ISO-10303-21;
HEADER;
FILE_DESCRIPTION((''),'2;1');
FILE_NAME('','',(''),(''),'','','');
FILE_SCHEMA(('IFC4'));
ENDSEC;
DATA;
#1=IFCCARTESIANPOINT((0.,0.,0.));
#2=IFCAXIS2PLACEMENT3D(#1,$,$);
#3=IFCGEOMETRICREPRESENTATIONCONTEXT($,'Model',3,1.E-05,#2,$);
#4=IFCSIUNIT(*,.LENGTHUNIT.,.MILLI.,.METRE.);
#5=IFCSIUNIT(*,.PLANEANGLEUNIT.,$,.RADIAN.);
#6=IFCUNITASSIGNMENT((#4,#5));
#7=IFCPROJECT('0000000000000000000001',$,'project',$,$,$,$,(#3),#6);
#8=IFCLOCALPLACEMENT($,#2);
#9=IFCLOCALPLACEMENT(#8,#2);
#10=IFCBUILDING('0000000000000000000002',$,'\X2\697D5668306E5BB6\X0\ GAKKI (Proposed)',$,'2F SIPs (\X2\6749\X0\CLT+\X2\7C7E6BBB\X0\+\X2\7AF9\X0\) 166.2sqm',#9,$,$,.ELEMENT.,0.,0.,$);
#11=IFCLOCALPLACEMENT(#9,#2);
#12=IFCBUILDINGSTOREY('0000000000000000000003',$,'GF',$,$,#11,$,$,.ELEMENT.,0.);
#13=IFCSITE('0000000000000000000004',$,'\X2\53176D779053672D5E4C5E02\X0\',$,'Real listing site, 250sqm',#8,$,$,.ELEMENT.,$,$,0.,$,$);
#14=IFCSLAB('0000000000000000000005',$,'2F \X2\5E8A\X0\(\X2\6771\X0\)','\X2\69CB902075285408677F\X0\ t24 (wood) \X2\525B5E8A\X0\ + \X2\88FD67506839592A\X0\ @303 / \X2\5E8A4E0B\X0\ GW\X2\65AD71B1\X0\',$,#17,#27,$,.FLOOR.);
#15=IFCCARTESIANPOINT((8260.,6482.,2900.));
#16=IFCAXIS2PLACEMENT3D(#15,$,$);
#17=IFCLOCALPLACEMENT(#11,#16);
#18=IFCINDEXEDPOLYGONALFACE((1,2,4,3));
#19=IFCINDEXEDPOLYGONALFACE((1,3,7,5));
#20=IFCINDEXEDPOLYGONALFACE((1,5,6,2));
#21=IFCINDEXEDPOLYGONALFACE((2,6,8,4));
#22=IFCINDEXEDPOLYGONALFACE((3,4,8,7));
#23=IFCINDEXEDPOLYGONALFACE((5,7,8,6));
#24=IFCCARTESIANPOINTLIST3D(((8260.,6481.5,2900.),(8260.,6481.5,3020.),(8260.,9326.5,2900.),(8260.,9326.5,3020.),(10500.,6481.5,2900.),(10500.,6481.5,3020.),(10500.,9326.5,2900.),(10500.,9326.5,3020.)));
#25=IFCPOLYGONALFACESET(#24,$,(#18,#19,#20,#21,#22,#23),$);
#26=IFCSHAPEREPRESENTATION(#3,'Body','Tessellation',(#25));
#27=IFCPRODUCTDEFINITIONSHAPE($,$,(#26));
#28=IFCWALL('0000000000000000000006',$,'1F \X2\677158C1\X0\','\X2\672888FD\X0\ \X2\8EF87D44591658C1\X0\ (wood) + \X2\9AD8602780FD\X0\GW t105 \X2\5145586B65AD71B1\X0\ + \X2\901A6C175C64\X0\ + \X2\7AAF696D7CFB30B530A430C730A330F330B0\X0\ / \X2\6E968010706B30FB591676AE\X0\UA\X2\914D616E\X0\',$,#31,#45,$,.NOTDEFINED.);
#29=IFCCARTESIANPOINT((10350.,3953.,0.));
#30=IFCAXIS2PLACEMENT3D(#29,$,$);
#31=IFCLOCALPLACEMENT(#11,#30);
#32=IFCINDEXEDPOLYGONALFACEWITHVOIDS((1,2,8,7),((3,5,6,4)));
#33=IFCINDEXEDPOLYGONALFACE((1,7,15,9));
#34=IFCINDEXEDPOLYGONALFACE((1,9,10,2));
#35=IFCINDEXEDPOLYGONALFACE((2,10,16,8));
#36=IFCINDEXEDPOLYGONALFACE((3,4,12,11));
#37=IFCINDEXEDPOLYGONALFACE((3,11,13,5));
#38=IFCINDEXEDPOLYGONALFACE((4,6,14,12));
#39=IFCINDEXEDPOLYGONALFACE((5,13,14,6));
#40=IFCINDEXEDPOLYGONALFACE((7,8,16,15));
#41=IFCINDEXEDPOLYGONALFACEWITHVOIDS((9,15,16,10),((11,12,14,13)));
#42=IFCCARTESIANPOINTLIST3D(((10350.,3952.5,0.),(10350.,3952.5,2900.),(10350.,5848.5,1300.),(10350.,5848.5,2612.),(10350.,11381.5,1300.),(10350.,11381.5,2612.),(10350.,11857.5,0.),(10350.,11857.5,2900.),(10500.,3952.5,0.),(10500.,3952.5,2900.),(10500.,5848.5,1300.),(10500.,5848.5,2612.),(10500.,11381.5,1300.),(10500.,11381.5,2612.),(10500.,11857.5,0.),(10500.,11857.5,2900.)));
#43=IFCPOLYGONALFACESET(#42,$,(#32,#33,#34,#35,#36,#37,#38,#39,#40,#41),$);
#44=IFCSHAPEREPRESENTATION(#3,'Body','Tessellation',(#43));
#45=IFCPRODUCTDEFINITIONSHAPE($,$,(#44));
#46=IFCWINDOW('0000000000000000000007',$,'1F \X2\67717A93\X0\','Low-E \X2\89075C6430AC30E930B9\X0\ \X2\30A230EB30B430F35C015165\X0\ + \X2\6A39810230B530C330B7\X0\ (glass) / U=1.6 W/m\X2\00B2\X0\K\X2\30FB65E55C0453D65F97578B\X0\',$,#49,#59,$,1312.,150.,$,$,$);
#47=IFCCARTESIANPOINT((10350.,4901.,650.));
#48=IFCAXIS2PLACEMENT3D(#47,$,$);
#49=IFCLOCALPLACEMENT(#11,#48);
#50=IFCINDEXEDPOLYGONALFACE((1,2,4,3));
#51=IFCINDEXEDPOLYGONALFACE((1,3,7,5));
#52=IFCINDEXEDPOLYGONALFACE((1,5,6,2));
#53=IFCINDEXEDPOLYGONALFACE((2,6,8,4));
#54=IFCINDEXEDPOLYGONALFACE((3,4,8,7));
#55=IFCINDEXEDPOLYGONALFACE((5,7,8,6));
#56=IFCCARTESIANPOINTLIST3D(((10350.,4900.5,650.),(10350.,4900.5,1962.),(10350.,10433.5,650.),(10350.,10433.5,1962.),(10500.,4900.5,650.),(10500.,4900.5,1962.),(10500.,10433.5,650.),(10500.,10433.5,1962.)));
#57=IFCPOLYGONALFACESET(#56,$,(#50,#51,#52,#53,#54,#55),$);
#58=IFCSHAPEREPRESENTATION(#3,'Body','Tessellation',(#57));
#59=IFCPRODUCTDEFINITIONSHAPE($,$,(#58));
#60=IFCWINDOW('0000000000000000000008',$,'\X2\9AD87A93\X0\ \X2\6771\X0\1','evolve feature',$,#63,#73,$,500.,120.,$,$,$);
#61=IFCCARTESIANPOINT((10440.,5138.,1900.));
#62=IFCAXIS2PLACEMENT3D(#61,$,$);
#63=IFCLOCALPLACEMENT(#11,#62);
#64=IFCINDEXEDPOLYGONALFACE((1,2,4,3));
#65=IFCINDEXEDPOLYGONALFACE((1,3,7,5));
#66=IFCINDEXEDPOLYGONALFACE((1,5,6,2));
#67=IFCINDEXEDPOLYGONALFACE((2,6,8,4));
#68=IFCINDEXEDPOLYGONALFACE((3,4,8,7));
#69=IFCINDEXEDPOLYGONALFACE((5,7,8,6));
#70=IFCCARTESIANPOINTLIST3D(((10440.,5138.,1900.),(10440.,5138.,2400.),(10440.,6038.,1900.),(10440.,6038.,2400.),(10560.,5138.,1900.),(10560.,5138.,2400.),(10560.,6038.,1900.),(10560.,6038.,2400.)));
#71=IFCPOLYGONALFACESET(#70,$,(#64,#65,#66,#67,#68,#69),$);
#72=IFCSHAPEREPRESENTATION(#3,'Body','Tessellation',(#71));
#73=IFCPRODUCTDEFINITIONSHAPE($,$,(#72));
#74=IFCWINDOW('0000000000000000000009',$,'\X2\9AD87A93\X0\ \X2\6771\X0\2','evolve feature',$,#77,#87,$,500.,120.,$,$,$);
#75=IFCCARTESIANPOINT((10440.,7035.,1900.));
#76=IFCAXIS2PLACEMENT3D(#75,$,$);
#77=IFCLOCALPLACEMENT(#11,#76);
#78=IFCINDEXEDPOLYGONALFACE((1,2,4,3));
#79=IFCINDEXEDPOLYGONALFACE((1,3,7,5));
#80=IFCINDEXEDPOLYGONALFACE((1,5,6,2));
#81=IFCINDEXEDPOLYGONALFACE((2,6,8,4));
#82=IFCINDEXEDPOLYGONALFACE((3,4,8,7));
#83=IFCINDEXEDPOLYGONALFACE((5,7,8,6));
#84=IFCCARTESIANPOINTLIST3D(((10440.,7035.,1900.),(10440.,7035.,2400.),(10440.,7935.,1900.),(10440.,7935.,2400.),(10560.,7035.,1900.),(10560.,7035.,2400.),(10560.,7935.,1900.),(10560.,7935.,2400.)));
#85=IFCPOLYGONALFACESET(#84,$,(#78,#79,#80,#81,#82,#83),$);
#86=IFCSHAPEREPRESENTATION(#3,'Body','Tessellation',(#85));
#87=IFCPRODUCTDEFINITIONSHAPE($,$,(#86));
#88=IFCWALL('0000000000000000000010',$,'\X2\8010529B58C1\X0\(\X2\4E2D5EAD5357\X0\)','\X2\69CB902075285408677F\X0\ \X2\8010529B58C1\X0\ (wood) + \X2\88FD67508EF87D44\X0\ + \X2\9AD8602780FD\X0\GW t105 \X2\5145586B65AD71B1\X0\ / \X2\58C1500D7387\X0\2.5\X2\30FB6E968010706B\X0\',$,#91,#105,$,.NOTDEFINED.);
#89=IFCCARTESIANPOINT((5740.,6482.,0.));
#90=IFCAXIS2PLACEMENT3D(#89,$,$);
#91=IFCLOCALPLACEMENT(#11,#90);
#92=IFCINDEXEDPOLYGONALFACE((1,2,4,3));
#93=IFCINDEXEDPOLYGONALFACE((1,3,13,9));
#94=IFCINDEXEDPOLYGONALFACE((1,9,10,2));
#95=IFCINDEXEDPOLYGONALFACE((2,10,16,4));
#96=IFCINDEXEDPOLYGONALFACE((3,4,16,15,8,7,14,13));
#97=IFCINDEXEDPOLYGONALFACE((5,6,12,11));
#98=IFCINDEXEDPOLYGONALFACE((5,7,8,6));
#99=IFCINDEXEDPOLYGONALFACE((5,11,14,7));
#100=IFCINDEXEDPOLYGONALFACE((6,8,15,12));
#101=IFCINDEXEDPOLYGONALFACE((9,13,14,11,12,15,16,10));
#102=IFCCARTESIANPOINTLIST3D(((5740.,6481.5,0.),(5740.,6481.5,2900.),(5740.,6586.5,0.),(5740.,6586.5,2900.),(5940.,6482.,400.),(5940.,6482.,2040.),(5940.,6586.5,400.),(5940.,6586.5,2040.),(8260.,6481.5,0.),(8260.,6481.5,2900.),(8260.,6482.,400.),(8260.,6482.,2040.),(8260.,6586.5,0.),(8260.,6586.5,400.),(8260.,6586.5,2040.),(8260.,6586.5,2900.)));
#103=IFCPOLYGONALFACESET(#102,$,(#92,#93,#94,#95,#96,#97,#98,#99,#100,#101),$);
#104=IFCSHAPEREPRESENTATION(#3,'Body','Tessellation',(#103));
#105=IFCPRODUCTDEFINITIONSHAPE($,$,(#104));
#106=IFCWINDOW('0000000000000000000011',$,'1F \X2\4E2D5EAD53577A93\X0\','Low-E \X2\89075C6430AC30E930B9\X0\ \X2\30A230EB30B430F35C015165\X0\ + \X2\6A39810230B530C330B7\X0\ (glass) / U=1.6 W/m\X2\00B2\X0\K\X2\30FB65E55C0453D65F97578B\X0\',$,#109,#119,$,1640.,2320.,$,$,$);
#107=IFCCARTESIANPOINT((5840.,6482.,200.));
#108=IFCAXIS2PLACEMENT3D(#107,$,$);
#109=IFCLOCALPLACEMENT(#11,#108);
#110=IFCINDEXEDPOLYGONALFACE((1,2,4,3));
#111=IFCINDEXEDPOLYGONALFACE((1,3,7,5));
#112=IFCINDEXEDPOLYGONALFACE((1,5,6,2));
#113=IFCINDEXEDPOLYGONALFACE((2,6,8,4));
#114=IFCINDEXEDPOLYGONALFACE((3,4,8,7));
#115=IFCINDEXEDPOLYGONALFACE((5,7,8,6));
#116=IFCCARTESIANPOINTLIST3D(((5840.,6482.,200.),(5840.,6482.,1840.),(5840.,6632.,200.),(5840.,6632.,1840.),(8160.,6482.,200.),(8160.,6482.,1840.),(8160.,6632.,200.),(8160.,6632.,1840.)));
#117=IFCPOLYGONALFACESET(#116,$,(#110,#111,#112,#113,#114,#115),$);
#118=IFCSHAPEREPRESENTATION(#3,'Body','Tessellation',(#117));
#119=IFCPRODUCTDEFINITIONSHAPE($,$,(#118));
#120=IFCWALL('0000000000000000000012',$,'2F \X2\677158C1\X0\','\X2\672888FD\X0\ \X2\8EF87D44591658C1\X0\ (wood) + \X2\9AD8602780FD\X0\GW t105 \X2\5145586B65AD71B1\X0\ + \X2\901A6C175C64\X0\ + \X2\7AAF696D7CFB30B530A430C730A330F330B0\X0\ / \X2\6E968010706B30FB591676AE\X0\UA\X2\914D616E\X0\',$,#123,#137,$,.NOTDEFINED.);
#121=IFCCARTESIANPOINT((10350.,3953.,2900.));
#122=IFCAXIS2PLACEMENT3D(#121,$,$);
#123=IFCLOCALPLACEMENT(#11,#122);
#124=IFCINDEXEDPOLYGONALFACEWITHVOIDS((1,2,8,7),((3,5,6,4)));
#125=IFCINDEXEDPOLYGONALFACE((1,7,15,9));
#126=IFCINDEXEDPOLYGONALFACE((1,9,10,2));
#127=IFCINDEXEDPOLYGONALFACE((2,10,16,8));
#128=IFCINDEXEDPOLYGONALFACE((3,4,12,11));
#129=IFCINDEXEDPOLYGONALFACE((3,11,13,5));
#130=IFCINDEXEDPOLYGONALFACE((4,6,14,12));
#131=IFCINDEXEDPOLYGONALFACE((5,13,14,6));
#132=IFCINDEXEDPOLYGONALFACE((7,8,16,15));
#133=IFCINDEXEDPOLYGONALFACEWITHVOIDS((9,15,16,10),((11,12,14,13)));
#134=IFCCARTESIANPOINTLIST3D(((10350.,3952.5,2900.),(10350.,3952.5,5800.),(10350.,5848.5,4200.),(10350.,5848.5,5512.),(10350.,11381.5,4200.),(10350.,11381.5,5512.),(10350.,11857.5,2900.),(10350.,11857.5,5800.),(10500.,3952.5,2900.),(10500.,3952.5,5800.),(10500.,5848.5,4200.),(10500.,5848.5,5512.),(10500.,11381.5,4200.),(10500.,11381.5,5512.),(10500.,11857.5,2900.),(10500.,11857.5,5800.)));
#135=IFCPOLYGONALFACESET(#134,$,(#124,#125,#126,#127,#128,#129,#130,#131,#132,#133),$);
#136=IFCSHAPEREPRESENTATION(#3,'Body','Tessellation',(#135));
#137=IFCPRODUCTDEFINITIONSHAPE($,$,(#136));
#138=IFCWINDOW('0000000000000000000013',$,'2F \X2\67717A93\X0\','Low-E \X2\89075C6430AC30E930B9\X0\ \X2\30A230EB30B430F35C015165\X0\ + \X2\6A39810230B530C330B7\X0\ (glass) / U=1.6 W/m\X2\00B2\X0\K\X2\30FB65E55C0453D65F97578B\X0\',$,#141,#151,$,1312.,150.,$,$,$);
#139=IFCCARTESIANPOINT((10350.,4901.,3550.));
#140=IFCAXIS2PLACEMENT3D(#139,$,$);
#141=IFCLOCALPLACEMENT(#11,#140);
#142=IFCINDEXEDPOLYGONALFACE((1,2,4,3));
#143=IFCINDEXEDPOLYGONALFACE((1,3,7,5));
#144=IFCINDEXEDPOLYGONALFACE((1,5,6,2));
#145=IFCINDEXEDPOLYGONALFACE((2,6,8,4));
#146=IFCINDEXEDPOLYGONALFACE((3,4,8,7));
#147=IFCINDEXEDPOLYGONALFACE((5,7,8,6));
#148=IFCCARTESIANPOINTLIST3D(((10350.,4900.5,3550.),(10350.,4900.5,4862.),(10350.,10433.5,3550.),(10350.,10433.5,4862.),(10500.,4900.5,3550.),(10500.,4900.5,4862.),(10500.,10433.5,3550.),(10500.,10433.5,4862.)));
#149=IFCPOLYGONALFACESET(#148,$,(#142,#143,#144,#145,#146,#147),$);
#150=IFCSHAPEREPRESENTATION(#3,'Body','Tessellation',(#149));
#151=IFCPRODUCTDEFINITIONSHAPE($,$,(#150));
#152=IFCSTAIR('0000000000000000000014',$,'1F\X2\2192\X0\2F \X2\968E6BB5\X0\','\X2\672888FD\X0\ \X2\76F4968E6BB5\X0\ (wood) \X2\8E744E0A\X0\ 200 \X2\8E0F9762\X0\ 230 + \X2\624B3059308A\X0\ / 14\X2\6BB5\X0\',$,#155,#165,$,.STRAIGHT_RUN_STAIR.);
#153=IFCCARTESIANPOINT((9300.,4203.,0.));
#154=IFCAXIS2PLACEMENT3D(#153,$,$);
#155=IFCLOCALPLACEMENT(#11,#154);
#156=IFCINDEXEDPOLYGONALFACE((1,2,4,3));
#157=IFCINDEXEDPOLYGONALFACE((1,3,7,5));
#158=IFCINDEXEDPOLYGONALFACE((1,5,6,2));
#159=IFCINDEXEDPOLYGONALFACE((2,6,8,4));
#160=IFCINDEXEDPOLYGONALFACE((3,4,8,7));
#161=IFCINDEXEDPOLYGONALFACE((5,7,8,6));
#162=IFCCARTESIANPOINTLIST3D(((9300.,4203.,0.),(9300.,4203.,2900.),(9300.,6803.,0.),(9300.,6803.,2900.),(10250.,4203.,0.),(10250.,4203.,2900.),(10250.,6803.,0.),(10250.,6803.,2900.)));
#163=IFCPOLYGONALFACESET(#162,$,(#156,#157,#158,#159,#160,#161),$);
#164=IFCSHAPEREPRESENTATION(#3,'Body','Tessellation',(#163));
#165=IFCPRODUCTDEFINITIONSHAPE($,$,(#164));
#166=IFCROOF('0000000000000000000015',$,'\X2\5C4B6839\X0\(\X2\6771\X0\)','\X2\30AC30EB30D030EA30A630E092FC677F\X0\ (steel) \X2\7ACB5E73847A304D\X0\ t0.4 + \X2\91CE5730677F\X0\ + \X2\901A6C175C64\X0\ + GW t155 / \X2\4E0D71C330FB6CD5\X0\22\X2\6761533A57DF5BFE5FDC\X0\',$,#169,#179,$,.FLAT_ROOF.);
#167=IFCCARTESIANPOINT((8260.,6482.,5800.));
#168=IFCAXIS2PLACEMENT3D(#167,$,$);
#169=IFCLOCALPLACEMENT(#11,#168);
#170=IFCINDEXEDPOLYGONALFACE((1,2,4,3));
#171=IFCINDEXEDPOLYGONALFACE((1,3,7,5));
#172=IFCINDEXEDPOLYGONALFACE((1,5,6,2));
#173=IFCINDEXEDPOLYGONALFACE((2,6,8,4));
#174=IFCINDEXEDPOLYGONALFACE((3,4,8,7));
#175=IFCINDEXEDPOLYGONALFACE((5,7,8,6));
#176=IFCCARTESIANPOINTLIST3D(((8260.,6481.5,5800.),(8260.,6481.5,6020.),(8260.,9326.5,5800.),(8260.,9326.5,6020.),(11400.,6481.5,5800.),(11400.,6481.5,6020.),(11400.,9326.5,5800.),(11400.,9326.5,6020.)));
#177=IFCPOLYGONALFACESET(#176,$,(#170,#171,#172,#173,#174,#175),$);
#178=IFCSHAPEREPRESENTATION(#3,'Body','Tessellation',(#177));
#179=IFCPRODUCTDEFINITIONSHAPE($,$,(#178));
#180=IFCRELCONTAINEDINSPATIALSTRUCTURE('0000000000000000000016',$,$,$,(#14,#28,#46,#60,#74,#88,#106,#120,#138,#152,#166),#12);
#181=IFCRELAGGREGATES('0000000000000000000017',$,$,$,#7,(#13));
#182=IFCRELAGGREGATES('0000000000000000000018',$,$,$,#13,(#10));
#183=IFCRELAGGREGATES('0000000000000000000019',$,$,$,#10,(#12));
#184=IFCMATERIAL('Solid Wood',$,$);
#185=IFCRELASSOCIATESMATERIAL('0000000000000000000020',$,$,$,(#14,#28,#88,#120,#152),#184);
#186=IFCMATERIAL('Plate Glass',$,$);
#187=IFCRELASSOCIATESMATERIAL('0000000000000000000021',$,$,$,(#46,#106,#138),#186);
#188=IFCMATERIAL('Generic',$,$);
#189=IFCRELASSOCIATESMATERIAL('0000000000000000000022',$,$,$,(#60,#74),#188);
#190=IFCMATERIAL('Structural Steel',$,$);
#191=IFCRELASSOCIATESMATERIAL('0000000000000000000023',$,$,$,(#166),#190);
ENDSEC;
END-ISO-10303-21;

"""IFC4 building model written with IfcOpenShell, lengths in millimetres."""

from ifc_helpers import new_model, si_unit, frame, frame_2d, origin, place, context, project, spatial, rectangle, extrude, material, element, fill, save


model = new_model("IFC4")

# Units and contexts
model_context = context("Model", 3, precision=1e-05, world=origin())
ifc_project = project(units=[si_unit("LENGTHUNIT", "METRE", prefix="MILLI"), si_unit("PLANEANGLEUNIT", "RADIAN")], contexts=[model_context])

# Site, building, storey
site_placement = place(None, origin())
site = spatial("IfcSite", under=ifc_project, at=site_placement, Name="北海道札幌市", ObjectType="Real listing site, 250sqm", CompositionType="ELEMENT", RefElevation=0.0)
building_placement = place(site_placement, origin())
building = spatial("IfcBuilding", under=site, at=building_placement, Name="楽器の家 GAKKI (Proposed)", ObjectType="2F SIPs (杉CLT+籾殻+竹) 166.2sqm", CompositionType="ELEMENT", ElevationOfRefHeight=0.0, ElevationOfTerrain=0.0)
storey_placement = place(building_placement, origin())
storey = spatial("IfcBuildingStorey", under=building, at=storey_placement, Name="GF", CompositionType="ELEMENT", Elevation=0.0)

# Slab
ifc_material_1 = material(Name="Solid Wood")
slab_1_placement = place(storey_placement, frame((8260.0, 6482.0, 2900.0)))
element("IfcSlab", 1, at=slab_1_placement, inside=storey, material=ifc_material_1, Name="2F 床(東)", Description="構造用合板 t24 (wood) 剛床 + 製材根太 @303 / 床下 GW断熱", PredefinedType="FLOOR", context=model_context, shape_type="SweptSolid", body=[
    extrude(rectangle(XDim=2240.0, YDim=2845.0, at=frame_2d((1120.0, 1422.0))), frame((8260.0, 6482.0, 2900.0)), (0.0, 0.0, 1.0), 120.0),
])

# Wall, openings, windows
wall_1_placement = place(storey_placement, frame((10350.0, 3953.0, 0.0)))
wall_1 = element("IfcWall", 2, at=wall_1_placement, inside=storey, material=ifc_material_1, Name="1F 東壁", Description="木製 軸組外壁 (wood) + 高性能GW t105 充填断熱 + 通気層 + 窯業系サイディング / 準耐火・外皮UA配慮", PredefinedType="NOTDEFINED", context=model_context, shape_type="SweptSolid", body=[
    extrude(rectangle(XDim=150.0, YDim=7905.0, at=frame_2d((75.0, 3952.0))), frame((10350.0, 3953.0, 0.0)), (0.0, 0.0, 1.0), 2900.0),
])
opening_1_placement = place(storey_placement, frame((10350.0, 4901.0, 650.0)))
opening_1 = element("IfcOpeningElement", 3, at=opening_1_placement, cuts=wall_1, PredefinedType="NOTDEFINED", context=model_context, shape_type="SweptSolid", body=[
    extrude(rectangle(XDim=150.0, YDim=5533.0, at=frame_2d((75.0, 2766.0))), frame((10350.0, 4901.0, 650.0)), (0.0, 0.0, 1.0), 1312.0),
])
opening_2_placement = place(storey_placement, frame((10440.0, 5138.0, 1900.0)))
opening_2 = element("IfcOpeningElement", 4, at=opening_2_placement, cuts=wall_1, PredefinedType="NOTDEFINED", context=model_context, shape_type="SweptSolid", body=[
    extrude(rectangle(XDim=120.0, YDim=900.0, at=frame_2d((60.0, 450.0))), frame((10440.0, 5138.0, 1900.0)), (0.0, 0.0, 1.0), 500.0),
])
opening_3_placement = place(storey_placement, frame((10440.0, 7035.0, 1900.0)))
opening_3 = element("IfcOpeningElement", 5, at=opening_3_placement, cuts=wall_1, PredefinedType="NOTDEFINED", context=model_context, shape_type="SweptSolid", body=[
    extrude(rectangle(XDim=120.0, YDim=900.0, at=frame_2d((60.0, 450.0))), frame((10440.0, 7035.0, 1900.0)), (0.0, 0.0, 1.0), 500.0),
])
ifc_material_2 = material(Name="Plate Glass")
window_1_placement = place(storey_placement, frame((10350.0, 4901.0, 650.0)))
window_1 = element("IfcWindow", 6, at=window_1_placement, inside=storey, material=ifc_material_2, Name="1F 東窓", Description="Low-E 複層ガラス アルゴン封入 + 樹脂サッシ (glass) / U=1.6 W/m²K・日射取得型", OverallHeight=1312.0, OverallWidth=150.0, context=model_context, shape_type="SweptSolid", body=[
    extrude(rectangle(XDim=150.0, YDim=5533.0, at=frame_2d((75.0, 2766.0))), frame((10350.0, 4901.0, 650.0)), (0.0, 0.0, 1.0), 1312.0),
])
fill(opening_1, window_1)
ifc_material_3 = material(Name="Generic")
window_2_placement = place(storey_placement, frame((10440.0, 5138.0, 1900.0)))
window_2 = element("IfcWindow", 7, at=window_2_placement, inside=storey, material=ifc_material_3, Name="高窓 東1", Description="evolve feature", OverallHeight=500.0, OverallWidth=120.0, context=model_context, shape_type="SweptSolid", body=[
    extrude(rectangle(XDim=120.0, YDim=900.0, at=frame_2d((60.0, 450.0))), frame((10440.0, 5138.0, 1900.0)), (0.0, 0.0, 1.0), 500.0),
])
fill(opening_2, window_2)
window_3_placement = place(storey_placement, frame((10440.0, 7035.0, 1900.0)))
window_3 = element("IfcWindow", 8, at=window_3_placement, inside=storey, material=ifc_material_3, Name="高窓 東2", Description="evolve feature", OverallHeight=500.0, OverallWidth=120.0, context=model_context, shape_type="SweptSolid", body=[
    extrude(rectangle(XDim=120.0, YDim=900.0, at=frame_2d((60.0, 450.0))), frame((10440.0, 7035.0, 1900.0)), (0.0, 0.0, 1.0), 500.0),
])
fill(opening_3, window_3)

# Wall, opening, window
wall_2_placement = place(storey_placement, frame((5740.0, 6482.0, 0.0)))
wall_2 = element("IfcWall", 9, at=wall_2_placement, inside=storey, material=ifc_material_1, Name="耐力壁(中庭南)", Description="構造用合板 耐力壁 (wood) + 製材軸組 + 高性能GW t105 充填断熱 / 壁倍率2.5・準耐火", PredefinedType="NOTDEFINED", context=model_context, shape_type="SweptSolid", body=[
    extrude(rectangle(XDim=2520.0, YDim=105.0, at=frame_2d((1260.0, 52.0))), frame((5740.0, 6482.0, 0.0)), (0.0, 0.0, 1.0), 2900.0),
])
opening_4_placement = place(storey_placement, frame((5840.0, 6482.0, 200.0)))
opening_4 = element("IfcOpeningElement", 10, at=opening_4_placement, cuts=wall_2, PredefinedType="NOTDEFINED", context=model_context, shape_type="SweptSolid", body=[
    extrude(rectangle(XDim=2320.0, YDim=150.0, at=frame_2d((1160.0, 75.0))), frame((5840.0, 6482.0, 200.0)), (0.0, 0.0, 1.0), 1640.0),
])
window_4_placement = place(storey_placement, frame((5840.0, 6482.0, 200.0)))
window_4 = element("IfcWindow", 11, at=window_4_placement, inside=storey, material=ifc_material_2, Name="1F 中庭南窓", Description="Low-E 複層ガラス アルゴン封入 + 樹脂サッシ (glass) / U=1.6 W/m²K・日射取得型", OverallHeight=1640.0, OverallWidth=2320.0, context=model_context, shape_type="SweptSolid", body=[
    extrude(rectangle(XDim=2320.0, YDim=150.0, at=frame_2d((1160.0, 75.0))), frame((5840.0, 6482.0, 200.0)), (0.0, 0.0, 1.0), 1640.0),
])
fill(opening_4, window_4)

# Wall, opening, window
wall_3_placement = place(storey_placement, frame((10350.0, 3953.0, 2900.0)))
wall_3 = element("IfcWall", 12, at=wall_3_placement, inside=storey, material=ifc_material_1, Name="2F 東壁", Description="木製 軸組外壁 (wood) + 高性能GW t105 充填断熱 + 通気層 + 窯業系サイディング / 準耐火・外皮UA配慮", PredefinedType="NOTDEFINED", context=model_context, shape_type="SweptSolid", body=[
    extrude(rectangle(XDim=150.0, YDim=7905.0, at=frame_2d((75.0, 3952.0))), frame((10350.0, 3953.0, 2900.0)), (0.0, 0.0, 1.0), 2900.0),
])
opening_5_placement = place(storey_placement, frame((10350.0, 4901.0, 3550.0)))
opening_5 = element("IfcOpeningElement", 13, at=opening_5_placement, cuts=wall_3, PredefinedType="NOTDEFINED", context=model_context, shape_type="SweptSolid", body=[
    extrude(rectangle(XDim=150.0, YDim=5533.0, at=frame_2d((75.0, 2766.0))), frame((10350.0, 4901.0, 3550.0)), (0.0, 0.0, 1.0), 1312.0),
])
window_5_placement = place(storey_placement, frame((10350.0, 4901.0, 3550.0)))
window_5 = element("IfcWindow", 14, at=window_5_placement, inside=storey, material=ifc_material_2, Name="2F 東窓", Description="Low-E 複層ガラス アルゴン封入 + 樹脂サッシ (glass) / U=1.6 W/m²K・日射取得型", OverallHeight=1312.0, OverallWidth=150.0, context=model_context, shape_type="SweptSolid", body=[
    extrude(rectangle(XDim=150.0, YDim=5533.0, at=frame_2d((75.0, 2766.0))), frame((10350.0, 4901.0, 3550.0)), (0.0, 0.0, 1.0), 1312.0),
])
fill(opening_5, window_5)

# Stair
stair_placement = place(storey_placement, frame((9300.0, 4203.0, 0.0)))
element("IfcStair", 15, at=stair_placement, inside=storey, material=ifc_material_1, Name="1F→2F 階段", Description="木製 直階段 (wood) 蹴上 200 踏面 230 + 手すり / 14段", PredefinedType="STRAIGHT_RUN_STAIR", context=model_context, shape_type="SweptSolid", body=[
    extrude(rectangle(XDim=950.0, YDim=2600.0, at=frame_2d((475.0, 1300.0))), frame((9300.0, 4203.0, 0.0)), (0.0, 0.0, 1.0), 2900.0),
])

# Roof
ifc_material_4 = material(Name="Structural Steel")
roof_placement = place(storey_placement, frame((8260.0, 6482.0, 5800.0)))
element("IfcRoof", 16, at=roof_placement, inside=storey, material=ifc_material_4, Name="屋根(東)", Description="ガルバリウム鋼板 (steel) 立平葺き t0.4 + 野地板 + 通気層 + GW t155 / 不燃・法22条区域対応", PredefinedType="FLAT_ROOF", context=model_context, shape_type="SweptSolid", body=[
    extrude(rectangle(XDim=3140.0, YDim=2845.0, at=frame_2d((1570.0, 1422.0))), frame((8260.0, 6482.0, 5800.0)), (0.0, 0.0, 1.0), 220.0),
])

save(model, "model.ifc")
